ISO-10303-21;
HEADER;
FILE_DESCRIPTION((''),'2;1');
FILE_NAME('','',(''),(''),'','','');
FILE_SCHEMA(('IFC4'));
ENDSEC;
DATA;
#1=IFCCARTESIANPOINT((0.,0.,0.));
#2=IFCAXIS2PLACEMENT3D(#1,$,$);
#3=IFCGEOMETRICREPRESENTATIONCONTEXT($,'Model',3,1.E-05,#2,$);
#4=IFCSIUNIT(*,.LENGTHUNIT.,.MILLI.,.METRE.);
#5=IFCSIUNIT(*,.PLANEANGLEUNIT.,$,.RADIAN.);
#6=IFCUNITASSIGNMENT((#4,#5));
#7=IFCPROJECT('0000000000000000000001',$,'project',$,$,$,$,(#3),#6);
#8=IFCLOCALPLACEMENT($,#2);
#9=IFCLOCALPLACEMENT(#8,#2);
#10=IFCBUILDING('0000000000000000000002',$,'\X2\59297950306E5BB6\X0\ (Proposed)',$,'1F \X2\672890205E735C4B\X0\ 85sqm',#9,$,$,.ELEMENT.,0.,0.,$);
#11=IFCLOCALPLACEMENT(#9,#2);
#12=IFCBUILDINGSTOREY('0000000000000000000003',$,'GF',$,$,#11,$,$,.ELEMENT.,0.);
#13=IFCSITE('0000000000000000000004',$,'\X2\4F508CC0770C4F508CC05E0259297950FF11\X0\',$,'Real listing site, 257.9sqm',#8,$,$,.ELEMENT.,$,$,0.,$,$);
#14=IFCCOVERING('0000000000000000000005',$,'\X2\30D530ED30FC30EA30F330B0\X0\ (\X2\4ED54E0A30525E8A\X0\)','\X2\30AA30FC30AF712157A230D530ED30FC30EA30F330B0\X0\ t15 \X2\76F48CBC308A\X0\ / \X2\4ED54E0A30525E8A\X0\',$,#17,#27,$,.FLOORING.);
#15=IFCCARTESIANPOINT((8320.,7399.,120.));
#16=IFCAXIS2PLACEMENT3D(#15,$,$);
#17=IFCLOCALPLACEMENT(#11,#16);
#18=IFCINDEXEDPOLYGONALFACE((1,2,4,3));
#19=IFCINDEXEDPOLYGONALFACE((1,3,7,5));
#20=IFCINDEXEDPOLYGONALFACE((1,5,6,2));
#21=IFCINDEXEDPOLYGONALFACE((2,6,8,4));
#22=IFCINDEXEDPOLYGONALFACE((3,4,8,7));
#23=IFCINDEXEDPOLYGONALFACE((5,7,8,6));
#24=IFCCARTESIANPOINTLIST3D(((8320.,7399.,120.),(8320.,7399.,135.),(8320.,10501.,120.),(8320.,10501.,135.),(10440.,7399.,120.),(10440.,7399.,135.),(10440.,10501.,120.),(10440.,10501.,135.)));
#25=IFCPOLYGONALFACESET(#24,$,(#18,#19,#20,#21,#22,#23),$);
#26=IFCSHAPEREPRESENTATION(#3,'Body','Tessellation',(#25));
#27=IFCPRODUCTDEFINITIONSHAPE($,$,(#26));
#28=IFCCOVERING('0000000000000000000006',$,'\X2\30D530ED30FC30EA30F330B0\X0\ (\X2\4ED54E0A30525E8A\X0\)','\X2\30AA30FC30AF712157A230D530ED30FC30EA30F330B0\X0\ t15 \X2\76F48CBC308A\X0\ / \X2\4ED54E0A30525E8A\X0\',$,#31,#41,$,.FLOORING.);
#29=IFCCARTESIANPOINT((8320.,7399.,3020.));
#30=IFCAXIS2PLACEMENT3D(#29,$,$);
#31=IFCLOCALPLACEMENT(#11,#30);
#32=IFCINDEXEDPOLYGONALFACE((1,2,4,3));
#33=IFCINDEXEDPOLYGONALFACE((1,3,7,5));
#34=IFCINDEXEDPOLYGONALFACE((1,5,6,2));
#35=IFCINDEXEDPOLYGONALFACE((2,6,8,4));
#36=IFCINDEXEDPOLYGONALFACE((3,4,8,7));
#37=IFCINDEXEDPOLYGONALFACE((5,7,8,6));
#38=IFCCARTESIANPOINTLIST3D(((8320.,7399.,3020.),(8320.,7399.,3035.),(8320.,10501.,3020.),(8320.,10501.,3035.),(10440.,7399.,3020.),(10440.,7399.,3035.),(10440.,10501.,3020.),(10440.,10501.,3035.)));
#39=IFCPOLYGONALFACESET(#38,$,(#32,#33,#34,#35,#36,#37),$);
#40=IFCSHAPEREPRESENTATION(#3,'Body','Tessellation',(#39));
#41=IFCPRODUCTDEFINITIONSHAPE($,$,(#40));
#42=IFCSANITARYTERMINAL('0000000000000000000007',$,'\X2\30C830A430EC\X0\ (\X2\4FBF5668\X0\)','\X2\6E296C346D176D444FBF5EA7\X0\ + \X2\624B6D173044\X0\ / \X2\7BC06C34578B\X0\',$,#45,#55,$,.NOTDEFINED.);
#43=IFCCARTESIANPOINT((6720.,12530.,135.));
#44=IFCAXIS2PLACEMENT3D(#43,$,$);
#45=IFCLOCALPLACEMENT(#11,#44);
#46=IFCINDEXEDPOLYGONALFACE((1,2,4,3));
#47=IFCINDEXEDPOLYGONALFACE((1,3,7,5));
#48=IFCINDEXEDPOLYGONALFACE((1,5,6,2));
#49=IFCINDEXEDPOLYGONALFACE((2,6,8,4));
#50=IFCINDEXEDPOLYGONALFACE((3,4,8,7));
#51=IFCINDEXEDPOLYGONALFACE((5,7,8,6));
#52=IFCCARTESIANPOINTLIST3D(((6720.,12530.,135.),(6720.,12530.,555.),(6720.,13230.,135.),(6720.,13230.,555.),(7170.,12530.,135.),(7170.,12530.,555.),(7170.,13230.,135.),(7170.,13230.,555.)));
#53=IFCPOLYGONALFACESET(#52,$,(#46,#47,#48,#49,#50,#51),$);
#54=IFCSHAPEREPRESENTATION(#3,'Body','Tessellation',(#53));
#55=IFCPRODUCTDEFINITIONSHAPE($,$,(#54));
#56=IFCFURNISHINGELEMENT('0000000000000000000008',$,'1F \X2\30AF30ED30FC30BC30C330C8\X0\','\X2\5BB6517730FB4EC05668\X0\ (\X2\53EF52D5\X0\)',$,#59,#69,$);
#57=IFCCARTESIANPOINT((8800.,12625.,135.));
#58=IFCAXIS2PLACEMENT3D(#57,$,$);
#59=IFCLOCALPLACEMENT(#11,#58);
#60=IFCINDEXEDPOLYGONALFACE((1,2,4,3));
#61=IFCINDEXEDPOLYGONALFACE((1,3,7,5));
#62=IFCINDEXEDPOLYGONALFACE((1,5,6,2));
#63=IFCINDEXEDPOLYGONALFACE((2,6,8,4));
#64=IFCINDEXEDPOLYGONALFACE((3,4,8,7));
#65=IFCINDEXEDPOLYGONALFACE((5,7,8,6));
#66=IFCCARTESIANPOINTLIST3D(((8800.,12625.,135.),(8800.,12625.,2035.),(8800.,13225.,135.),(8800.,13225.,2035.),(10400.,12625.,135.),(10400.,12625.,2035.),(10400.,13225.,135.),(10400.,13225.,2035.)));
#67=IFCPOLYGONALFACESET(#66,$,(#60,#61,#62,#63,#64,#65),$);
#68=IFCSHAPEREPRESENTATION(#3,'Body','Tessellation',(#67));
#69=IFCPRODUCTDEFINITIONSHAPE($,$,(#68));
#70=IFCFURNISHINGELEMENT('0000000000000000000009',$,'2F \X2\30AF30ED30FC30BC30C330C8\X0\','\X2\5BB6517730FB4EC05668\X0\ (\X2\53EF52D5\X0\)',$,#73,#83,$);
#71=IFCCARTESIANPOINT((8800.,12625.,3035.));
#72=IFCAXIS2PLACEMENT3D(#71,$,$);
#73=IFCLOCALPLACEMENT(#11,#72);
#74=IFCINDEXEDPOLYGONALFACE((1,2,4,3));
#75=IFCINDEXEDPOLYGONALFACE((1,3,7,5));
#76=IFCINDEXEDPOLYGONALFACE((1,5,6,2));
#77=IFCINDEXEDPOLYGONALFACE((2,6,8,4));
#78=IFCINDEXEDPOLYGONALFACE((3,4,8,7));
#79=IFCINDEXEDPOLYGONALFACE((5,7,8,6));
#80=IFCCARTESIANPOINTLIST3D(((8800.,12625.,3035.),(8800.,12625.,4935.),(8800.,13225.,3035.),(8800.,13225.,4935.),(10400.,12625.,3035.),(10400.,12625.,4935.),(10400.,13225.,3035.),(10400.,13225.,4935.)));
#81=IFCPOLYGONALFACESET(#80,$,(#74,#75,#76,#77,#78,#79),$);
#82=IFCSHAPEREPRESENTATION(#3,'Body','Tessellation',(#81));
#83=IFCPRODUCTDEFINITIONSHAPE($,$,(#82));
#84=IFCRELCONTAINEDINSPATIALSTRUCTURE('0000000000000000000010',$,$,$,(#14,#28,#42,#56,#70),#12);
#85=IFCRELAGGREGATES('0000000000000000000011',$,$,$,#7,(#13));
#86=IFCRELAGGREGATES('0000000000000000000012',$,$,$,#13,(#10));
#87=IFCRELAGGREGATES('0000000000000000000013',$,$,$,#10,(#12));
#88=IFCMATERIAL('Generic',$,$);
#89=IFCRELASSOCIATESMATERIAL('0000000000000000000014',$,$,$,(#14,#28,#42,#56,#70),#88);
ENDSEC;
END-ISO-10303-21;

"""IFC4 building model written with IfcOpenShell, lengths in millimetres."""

from ifc_helpers import new_model, si_unit, frame, frame_2d, origin, place, context, project, spatial, rectangle, extrude, material, element, save


model = new_model("IFC4")

# Units and contexts
model_context = context("Model", 3, precision=1e-05, world=origin())
ifc_project = project(units=[si_unit("LENGTHUNIT", "METRE", prefix="MILLI"), si_unit("PLANEANGLEUNIT", "RADIAN")], contexts=[model_context])

# Site, building, storey
site_placement = place(None, origin())
site = spatial("IfcSite", under=ifc_project, at=site_placement, Name="佐賀県佐賀市天祐１", ObjectType="Real listing site, 257.9sqm", CompositionType="ELEMENT", RefElevation=0.0)
building_placement = place(site_placement, origin())
building = spatial("IfcBuilding", under=site, at=building_placement, Name="天祐の家 (Proposed)", ObjectType="1F 木造平屋 85sqm", CompositionType="ELEMENT", ElevationOfRefHeight=0.0, ElevationOfTerrain=0.0)
storey_placement = place(building_placement, origin())
storey = spatial("IfcBuildingStorey", under=building, at=storey_placement, Name="GF", CompositionType="ELEMENT", Elevation=0.0)

# Shared definitions
ifc_material_1 = material(Name="Generic")

# Coverings
covering_1_placement = place(storey_placement, frame((8320.0, 7399.0, 120.0)))
element("IfcCovering", 1, at=covering_1_placement, inside=storey, material=ifc_material_1, Name="フローリング (仕上げ床)", Description="オーク無垢フローリング t15 直貼り / 仕上げ床", PredefinedType="FLOORING", context=model_context, shape_type="SweptSolid", body=[
    extrude(rectangle(XDim=2120.0, YDim=3102.0, at=frame_2d((1060.0, 1551.0))), frame((8320.0, 7399.0, 120.0)), (0.0, 0.0, 1.0), 15.0),
])
covering_2_placement = place(storey_placement, frame((8320.0, 7399.0, 3020.0)))
element("IfcCovering", 2, at=covering_2_placement, inside=storey, material=ifc_material_1, Name="フローリング (仕上げ床)", Description="オーク無垢フローリング t15 直貼り / 仕上げ床", PredefinedType="FLOORING", context=model_context, shape_type="SweptSolid", body=[
    extrude(rectangle(XDim=2120.0, YDim=3102.0, at=frame_2d((1060.0, 1551.0))), frame((8320.0, 7399.0, 3020.0)), (0.0, 0.0, 1.0), 15.0),
])

# Sanitary terminal
sanitary_terminal_placement = place(storey_placement, frame((6720.0, 12530.0, 135.0)))
element("IfcSanitaryTerminal", 3, at=sanitary_terminal_placement, inside=storey, material=ifc_material_1, Name="トイレ (便器)", Description="温水洗浄便座 + 手洗い / 節水型", PredefinedType="NOTDEFINED", context=model_context, shape_type="SweptSolid", body=[
    extrude(rectangle(XDim=450.0, YDim=700.0, at=frame_2d((225.0, 350.0))), frame((6720.0, 12530.0, 135.0)), (0.0, 0.0, 1.0), 420.0),
])

# Furnishing elements
furnishing_1_placement = place(storey_placement, frame((8800.0, 12625.0, 135.0)))
element("IfcFurnishingElement", 4, at=furnishing_1_placement, inside=storey, material=ifc_material_1, Name="1F クローゼット", Description="家具・什器 (可動)", context=model_context, shape_type="SweptSolid", body=[
    extrude(rectangle(XDim=1600.0, YDim=600.0, at=frame_2d((800.0, 300.0))), frame((8800.0, 12625.0, 135.0)), (0.0, 0.0, 1.0), 1900.0),
])
furnishing_2_placement = place(storey_placement, frame((8800.0, 12625.0, 3035.0)))
element("IfcFurnishingElement", 5, at=furnishing_2_placement, inside=storey, material=ifc_material_1, Name="2F クローゼット", Description="家具・什器 (可動)", context=model_context, shape_type="SweptSolid", body=[
    extrude(rectangle(XDim=1600.0, YDim=600.0, at=frame_2d((800.0, 300.0))), frame((8800.0, 12625.0, 3035.0)), (0.0, 0.0, 1.0), 1900.0),
])

save(model, "model.ifc")
